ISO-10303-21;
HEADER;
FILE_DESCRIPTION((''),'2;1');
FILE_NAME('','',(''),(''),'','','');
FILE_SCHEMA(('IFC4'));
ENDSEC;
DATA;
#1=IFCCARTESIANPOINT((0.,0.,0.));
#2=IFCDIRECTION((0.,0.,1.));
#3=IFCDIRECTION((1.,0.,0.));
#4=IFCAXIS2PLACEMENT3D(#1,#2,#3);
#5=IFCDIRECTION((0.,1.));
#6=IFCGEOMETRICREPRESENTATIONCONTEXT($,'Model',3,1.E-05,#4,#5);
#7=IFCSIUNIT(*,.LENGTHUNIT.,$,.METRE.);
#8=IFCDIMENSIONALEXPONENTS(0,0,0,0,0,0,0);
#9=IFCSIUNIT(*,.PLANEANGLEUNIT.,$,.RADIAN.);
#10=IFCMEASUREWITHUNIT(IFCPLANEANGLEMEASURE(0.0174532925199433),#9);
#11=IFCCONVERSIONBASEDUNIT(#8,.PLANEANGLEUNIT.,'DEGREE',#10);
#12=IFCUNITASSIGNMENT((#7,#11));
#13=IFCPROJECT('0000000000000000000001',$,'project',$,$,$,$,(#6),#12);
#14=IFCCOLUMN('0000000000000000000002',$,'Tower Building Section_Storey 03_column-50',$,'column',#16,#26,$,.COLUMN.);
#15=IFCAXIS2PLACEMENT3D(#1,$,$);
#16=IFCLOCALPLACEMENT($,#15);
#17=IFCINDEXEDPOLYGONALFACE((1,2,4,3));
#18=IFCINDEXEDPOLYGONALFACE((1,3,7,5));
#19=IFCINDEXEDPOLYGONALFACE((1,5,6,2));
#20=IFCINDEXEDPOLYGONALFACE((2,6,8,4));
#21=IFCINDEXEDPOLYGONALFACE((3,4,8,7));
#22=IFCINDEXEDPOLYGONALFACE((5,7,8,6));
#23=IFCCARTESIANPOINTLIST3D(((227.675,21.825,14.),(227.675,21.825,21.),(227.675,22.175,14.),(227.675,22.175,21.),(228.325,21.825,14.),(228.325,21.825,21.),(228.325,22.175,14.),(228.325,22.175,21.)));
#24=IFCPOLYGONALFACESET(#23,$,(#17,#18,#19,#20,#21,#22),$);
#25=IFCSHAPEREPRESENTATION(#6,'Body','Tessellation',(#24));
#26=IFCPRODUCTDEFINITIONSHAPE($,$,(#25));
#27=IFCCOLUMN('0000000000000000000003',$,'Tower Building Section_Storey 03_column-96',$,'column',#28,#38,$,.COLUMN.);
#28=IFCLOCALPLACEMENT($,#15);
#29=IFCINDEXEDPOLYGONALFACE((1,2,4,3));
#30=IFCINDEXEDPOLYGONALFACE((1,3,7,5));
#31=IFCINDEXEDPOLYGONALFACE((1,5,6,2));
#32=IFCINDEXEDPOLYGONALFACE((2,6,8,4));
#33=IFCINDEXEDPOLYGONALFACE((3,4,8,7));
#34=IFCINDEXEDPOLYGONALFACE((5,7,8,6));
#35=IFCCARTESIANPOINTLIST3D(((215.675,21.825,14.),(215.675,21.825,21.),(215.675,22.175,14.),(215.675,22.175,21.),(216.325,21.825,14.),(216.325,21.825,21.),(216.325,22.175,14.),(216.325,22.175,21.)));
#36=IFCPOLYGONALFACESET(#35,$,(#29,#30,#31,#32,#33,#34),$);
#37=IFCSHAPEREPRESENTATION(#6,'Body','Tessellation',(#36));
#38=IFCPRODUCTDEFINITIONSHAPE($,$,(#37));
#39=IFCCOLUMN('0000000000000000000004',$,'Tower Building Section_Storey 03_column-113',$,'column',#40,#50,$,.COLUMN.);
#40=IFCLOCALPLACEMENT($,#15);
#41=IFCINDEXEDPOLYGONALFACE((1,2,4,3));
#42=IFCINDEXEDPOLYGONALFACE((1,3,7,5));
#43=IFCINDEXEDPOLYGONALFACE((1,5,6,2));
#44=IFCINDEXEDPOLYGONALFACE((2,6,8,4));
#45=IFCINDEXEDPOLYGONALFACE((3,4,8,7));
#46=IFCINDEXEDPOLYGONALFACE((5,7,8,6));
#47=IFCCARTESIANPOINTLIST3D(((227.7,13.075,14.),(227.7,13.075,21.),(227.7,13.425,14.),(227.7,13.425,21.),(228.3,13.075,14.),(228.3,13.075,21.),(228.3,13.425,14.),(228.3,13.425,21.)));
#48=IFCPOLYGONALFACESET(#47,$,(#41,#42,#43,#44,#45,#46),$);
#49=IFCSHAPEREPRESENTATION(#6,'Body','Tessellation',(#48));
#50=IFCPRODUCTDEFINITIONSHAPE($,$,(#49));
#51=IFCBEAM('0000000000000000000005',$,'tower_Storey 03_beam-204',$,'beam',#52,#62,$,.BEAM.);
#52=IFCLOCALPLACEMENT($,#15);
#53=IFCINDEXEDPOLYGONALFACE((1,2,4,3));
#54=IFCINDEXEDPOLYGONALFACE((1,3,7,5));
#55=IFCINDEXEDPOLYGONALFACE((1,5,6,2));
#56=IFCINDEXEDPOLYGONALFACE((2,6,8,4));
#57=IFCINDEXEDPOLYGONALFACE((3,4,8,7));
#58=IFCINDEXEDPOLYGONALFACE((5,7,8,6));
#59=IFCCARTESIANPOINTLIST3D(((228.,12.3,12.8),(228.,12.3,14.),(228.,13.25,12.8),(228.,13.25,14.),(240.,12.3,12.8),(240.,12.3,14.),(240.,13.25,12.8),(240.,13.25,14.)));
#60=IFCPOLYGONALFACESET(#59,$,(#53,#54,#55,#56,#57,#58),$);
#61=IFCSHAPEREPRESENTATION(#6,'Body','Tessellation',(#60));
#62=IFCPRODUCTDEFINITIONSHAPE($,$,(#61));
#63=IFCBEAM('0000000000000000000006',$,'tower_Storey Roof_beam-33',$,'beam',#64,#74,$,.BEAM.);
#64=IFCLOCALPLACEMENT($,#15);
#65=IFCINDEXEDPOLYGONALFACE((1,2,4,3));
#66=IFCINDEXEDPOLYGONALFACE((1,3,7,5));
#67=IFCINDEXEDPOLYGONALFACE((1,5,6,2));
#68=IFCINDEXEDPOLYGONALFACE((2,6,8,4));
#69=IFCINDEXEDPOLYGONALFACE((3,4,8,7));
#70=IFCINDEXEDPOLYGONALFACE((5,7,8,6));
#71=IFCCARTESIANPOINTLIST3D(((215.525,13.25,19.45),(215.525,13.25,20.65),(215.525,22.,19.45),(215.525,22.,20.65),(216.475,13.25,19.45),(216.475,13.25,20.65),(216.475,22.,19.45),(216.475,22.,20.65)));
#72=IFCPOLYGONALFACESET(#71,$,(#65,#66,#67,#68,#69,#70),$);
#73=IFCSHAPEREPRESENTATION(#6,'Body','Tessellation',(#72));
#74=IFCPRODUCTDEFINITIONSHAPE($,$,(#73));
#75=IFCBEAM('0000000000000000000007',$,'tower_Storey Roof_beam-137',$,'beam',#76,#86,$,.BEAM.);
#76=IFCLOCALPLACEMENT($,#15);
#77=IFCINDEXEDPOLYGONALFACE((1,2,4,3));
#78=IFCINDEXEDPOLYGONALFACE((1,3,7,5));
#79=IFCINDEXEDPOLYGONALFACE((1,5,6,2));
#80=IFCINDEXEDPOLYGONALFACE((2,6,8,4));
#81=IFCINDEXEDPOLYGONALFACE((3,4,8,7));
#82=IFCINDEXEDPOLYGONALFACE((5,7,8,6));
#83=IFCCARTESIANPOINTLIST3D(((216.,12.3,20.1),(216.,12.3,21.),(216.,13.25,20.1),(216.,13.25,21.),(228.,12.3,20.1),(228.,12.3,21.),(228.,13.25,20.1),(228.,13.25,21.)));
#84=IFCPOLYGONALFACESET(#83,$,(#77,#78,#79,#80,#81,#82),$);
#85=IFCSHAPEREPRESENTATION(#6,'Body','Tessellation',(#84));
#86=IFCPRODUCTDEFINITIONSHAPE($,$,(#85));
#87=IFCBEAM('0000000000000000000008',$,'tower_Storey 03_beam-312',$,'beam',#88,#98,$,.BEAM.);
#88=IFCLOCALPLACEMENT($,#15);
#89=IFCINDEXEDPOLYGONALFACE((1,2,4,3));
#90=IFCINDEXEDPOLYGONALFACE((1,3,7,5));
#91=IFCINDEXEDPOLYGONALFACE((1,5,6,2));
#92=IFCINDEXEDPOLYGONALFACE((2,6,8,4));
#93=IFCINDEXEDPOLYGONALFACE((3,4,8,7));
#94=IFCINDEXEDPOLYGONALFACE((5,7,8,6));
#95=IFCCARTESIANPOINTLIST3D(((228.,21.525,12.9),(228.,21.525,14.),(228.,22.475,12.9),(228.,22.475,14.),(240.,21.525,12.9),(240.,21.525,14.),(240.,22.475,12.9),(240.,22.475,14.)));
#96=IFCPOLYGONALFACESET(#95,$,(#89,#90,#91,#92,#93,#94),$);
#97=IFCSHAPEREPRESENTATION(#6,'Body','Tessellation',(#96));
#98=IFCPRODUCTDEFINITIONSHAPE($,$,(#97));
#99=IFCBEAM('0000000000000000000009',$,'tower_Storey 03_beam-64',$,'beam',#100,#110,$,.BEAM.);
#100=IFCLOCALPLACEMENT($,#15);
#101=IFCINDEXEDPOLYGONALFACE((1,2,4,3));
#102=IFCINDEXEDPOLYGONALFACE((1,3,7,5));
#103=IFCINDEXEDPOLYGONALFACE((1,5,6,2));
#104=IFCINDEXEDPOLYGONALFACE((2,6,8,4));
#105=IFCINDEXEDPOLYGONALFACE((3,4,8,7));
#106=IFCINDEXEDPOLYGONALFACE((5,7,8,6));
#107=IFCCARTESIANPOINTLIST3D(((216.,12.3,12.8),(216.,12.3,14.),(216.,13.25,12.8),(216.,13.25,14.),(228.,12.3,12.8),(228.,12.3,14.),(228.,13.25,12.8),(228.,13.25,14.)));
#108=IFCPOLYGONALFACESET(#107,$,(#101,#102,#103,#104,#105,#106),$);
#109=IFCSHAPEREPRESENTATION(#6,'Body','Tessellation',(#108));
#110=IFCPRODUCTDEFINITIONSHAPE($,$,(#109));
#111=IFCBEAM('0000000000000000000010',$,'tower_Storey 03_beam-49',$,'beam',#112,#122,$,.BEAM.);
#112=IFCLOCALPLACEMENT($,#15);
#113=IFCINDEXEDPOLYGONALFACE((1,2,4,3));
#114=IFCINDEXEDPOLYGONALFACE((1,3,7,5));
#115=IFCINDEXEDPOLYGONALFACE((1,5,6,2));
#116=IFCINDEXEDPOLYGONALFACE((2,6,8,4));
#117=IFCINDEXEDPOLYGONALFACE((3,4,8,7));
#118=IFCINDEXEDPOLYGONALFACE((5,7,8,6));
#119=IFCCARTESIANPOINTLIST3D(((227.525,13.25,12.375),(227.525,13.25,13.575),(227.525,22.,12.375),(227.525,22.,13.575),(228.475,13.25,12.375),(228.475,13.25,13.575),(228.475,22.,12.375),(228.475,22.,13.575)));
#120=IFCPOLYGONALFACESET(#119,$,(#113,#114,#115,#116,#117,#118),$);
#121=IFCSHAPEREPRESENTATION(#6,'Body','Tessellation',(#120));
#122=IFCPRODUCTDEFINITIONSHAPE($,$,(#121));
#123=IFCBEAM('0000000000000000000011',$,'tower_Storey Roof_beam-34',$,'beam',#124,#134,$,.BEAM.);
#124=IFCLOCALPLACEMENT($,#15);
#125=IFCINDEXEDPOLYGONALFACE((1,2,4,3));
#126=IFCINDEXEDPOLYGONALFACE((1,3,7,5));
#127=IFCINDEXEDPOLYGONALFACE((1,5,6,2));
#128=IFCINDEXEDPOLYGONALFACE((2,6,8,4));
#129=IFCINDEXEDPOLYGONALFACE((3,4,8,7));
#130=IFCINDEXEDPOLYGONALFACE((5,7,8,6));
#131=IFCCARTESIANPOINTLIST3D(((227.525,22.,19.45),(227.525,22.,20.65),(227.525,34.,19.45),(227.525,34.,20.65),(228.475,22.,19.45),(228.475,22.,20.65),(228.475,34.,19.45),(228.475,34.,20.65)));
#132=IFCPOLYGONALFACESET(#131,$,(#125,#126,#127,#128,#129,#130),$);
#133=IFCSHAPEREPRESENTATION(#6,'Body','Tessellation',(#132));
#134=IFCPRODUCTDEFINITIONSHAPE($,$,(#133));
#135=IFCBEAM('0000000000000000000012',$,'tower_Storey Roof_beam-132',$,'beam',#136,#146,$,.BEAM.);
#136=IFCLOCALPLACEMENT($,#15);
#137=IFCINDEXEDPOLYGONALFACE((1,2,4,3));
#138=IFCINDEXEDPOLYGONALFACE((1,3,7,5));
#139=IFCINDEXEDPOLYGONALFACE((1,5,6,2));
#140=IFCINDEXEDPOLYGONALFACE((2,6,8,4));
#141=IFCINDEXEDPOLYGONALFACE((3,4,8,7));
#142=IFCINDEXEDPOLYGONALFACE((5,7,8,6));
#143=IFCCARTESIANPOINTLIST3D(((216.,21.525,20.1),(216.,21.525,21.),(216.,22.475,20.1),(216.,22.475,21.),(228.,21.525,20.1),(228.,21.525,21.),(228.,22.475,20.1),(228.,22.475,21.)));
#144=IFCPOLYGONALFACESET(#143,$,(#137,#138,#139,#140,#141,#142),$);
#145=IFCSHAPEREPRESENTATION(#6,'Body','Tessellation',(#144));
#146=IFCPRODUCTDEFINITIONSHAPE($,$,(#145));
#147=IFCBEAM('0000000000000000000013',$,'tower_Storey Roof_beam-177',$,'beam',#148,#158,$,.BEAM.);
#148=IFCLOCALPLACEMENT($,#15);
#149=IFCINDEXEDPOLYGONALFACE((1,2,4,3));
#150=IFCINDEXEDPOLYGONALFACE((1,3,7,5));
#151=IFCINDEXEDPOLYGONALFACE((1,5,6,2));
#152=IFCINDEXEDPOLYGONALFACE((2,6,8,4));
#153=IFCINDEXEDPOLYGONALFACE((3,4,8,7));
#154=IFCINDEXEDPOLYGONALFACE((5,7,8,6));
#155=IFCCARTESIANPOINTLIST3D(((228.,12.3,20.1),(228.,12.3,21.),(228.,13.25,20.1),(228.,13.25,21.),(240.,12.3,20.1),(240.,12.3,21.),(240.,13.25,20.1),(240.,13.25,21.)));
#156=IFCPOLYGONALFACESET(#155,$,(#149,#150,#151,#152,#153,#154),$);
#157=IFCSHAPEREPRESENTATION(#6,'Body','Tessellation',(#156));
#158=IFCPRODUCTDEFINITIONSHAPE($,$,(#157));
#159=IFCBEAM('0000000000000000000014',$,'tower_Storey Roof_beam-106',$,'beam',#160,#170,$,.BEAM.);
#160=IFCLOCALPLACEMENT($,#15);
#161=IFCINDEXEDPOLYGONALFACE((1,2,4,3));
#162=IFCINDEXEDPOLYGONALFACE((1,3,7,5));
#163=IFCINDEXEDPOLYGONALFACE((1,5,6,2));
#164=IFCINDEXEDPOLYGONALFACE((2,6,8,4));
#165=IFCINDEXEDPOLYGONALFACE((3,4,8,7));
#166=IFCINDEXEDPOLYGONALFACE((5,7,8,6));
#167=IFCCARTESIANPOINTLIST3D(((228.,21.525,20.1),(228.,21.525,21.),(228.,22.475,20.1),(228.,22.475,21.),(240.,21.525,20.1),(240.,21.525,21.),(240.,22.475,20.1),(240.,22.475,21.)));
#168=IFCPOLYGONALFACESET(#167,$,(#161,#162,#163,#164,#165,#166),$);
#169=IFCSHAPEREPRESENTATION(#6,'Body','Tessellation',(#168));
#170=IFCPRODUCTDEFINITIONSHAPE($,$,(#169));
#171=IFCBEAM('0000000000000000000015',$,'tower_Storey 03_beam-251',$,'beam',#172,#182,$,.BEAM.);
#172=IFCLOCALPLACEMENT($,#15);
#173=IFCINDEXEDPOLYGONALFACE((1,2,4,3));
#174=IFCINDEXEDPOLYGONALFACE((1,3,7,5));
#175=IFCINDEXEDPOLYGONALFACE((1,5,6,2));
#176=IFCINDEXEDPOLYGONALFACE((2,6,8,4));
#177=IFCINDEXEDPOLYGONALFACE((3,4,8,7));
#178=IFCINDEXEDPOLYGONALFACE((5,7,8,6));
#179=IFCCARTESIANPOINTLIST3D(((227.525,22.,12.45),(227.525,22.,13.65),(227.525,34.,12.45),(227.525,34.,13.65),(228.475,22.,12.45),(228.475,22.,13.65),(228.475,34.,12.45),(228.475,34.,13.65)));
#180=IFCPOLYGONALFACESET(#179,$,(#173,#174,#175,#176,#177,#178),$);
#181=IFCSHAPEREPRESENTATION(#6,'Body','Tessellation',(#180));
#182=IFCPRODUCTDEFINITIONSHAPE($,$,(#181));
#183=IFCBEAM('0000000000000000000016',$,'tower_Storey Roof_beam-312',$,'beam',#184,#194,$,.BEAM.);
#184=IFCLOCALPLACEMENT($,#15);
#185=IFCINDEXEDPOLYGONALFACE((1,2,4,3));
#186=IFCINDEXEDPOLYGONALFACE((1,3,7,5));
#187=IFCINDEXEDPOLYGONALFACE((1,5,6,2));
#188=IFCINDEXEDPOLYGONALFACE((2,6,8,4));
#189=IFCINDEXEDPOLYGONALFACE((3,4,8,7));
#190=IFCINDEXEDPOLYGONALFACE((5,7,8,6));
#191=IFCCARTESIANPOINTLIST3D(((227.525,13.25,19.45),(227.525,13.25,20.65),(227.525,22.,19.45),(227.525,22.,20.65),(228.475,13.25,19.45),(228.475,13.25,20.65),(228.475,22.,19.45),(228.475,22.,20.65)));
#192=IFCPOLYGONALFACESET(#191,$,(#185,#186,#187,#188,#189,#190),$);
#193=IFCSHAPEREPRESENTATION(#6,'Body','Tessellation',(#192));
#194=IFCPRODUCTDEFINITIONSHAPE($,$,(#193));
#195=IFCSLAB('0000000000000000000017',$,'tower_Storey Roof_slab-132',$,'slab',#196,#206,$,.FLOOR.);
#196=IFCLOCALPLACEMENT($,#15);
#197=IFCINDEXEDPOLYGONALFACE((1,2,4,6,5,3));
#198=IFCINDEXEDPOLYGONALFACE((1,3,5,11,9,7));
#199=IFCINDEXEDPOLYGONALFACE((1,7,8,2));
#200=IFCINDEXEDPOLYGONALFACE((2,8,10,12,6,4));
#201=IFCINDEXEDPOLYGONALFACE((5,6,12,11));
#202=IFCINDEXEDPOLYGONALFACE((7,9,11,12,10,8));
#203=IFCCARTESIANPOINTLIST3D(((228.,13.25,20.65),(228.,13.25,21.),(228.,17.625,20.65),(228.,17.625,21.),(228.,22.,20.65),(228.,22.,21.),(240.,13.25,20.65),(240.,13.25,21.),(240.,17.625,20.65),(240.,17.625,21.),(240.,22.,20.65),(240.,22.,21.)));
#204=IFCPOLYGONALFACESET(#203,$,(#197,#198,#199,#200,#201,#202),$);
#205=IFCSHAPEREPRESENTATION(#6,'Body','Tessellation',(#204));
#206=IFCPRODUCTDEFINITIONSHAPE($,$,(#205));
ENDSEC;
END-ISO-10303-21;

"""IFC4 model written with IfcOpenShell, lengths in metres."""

from ifc_helpers import new_model, entity, si_unit, converted_unit, direction, frame, origin_with_axes, place, context, project, polyline, outline, extrude, element, save


model = new_model("IFC4")

# Units and contexts
model_context = context("Model", 3, precision=1e-05, world=origin_with_axes(), true_north=direction((0.0, 1.0)))
ifc_project = project(units=[si_unit("LENGTHUNIT", "METRE"), converted_unit("PLANEANGLEUNIT", "DEGREE", entity("IfcPlaneAngleMeasure", 0.0174532925199433), si_unit("PLANEANGLEUNIT", "RADIAN"), dimensions=[0, 0, 0, 0, 0, 0, 0])], contexts=[model_context])

# Columns
placement_1 = place(None, origin_with_axes())
placement_2 = place(placement_1, frame((0.0, 0.0, 14.0), z_axis=(0.0, 0.0, 1.0), x_axis=(1.0, 0.0, 0.0)))
for number, where, z_axis, x_axis, name in (
    (1, (228.0, 22.0, 0.0), (0.0, 0.0, 1.0), (1.0, 0.0, 0.0), "Tower Building Section_Storey 03_column-50"),
    (2, (216.0, 22.0, 0.0), (0.0, 0.0, 1.0), (1.0, 0.0, 0.0), "Tower Building Section_Storey 03_column-96"),
):
    element("IfcColumn", number, at=place(placement_2, frame(where, z_axis=z_axis, x_axis=x_axis)), Name=name, ObjectType="column", PredefinedType="COLUMN", context=model_context, body=[
        extrude(outline(polyline([(-0.325, -0.175, 0.0), (0.325, -0.175, 0.0), (0.325, 0.175, 0.0), (-0.325, 0.175, 0.0), (-0.325, -0.175, 0.0)])), origin_with_axes(), (0.0, 0.0, 1.0), 7.0),
    ])
column_placement = place(placement_2, frame((228.0, 13.25, 0.0), z_axis=(0.0, 0.0, 1.0), x_axis=(1.0, 0.0, 0.0)))
element("IfcColumn", 3, at=column_placement, Name="Tower Building Section_Storey 03_column-113", ObjectType="column", PredefinedType="COLUMN", context=model_context, body=[
    extrude(outline(polyline([(-0.3, -0.175, 0.0), (0.3, -0.175, 0.0), (0.3, 0.175, 0.0), (-0.3, 0.175, 0.0), (-0.3, -0.175, 0.0)])), origin_with_axes(), (0.0, 0.0, 1.0), 7.0),
])

# Beams
beam_1_placement = place(placement_2, frame((228.0, 12.775, -0.6), z_axis=(1.0, 0.0, 0.0), x_axis=(0.0, 1.0, 0.0)))
element("IfcBeam", 4, at=beam_1_placement, Name="tower_Storey 03_beam-204", ObjectType="beam", PredefinedType="BEAM", context=model_context, body=[
    extrude(outline(polyline([(0.475, 0.6, 0.0), (-0.475, 0.6, 0.0), (-0.475, -0.6, 0.0), (0.475, -0.6, 0.0), (0.475, 0.6, 0.0)])), origin_with_axes(), (0.0, 0.0, 1.0), 12.0),
])
placement_3 = place(placement_1, frame((0.0, 0.0, 21.0), z_axis=(0.0, 0.0, 1.0), x_axis=(1.0, 0.0, 0.0)))
beam_2_placement = place(placement_3, frame((216.0, 13.25, -0.95), z_axis=(0.0, 1.0, 0.0), x_axis=(-1.0, 0.0, 0.0)))
element("IfcBeam", 5, at=beam_2_placement, Name="tower_Storey Roof_beam-33", ObjectType="beam", PredefinedType="BEAM", context=model_context, body=[
    extrude(outline(polyline([(0.475, 0.6, 0.0), (-0.475, 0.6, 0.0), (-0.475, -0.6, 0.0), (0.475, -0.6, 0.0), (0.475, 0.6, 0.0)])), origin_with_axes(), (0.0, 0.0, 1.0), 8.75),
])
beam_3_placement = place(placement_3, frame((216.0, 12.775, -0.45), z_axis=(1.0, 0.0, 0.0), x_axis=(0.0, 1.0, 0.0)))
element("IfcBeam", 6, at=beam_3_placement, Name="tower_Storey Roof_beam-137", ObjectType="beam", PredefinedType="BEAM", context=model_context, body=[
    extrude(outline(polyline([(0.475, 0.45, 0.0), (-0.475, 0.45, 0.0), (-0.475, -0.45, 0.0), (0.475, -0.45, 0.0), (0.475, 0.45, 0.0)])), origin_with_axes(), (0.0, 0.0, 1.0), 12.0),
])
beam_4_placement = place(placement_2, frame((228.0, 22.0, -0.55), z_axis=(1.0, 0.0, 0.0), x_axis=(0.0, 1.0, 0.0)))
element("IfcBeam", 7, at=beam_4_placement, Name="tower_Storey 03_beam-312", ObjectType="beam", PredefinedType="BEAM", context=model_context, body=[
    extrude(outline(polyline([(0.475, 0.55, 0.0), (-0.475, 0.55, 0.0), (-0.475, -0.55, 0.0), (0.475, -0.55, 0.0), (0.475, 0.55, 0.0)])), origin_with_axes(), (0.0, 0.0, 1.0), 12.0),
])
beam_5_placement = place(placement_2, frame((216.0, 12.775, -0.6), z_axis=(1.0, 0.0, 0.0), x_axis=(0.0, 1.0, 0.0)))
element("IfcBeam", 8, at=beam_5_placement, Name="tower_Storey 03_beam-64", ObjectType="beam", PredefinedType="BEAM", context=model_context, body=[
    extrude(outline(polyline([(0.475, 0.6, 0.0), (-0.475, 0.6, 0.0), (-0.475, -0.6, 0.0), (0.475, -0.6, 0.0), (0.475, 0.6, 0.0)])), origin_with_axes(), (0.0, 0.0, 1.0), 12.0),
])
beam_6_placement = place(placement_2, frame((228.0, 13.25, -1.025), z_axis=(0.0, 1.0, 0.0), x_axis=(-1.0, 0.0, 0.0)))
element("IfcBeam", 9, at=beam_6_placement, Name="tower_Storey 03_beam-49", ObjectType="beam", PredefinedType="BEAM", context=model_context, body=[
    extrude(outline(polyline([(0.475, 0.6, 0.0), (-0.475, 0.6, 0.0), (-0.475, -0.6, 0.0), (0.475, -0.6, 0.0), (0.475, 0.6, 0.0)])), origin_with_axes(), (0.0, 0.0, 1.0), 8.75),
])
beam_7_placement = place(placement_3, frame((228.0, 22.0, -0.95), z_axis=(0.0, 1.0, 0.0), x_axis=(-1.0, 0.0, 0.0)))
element("IfcBeam", 10, at=beam_7_placement, Name="tower_Storey Roof_beam-34", ObjectType="beam", PredefinedType="BEAM", context=model_context, body=[
    extrude(outline(polyline([(0.475, 0.6, 0.0), (-0.475, 0.6, 0.0), (-0.475, -0.6, 0.0), (0.475, -0.6, 0.0), (0.475, 0.6, 0.0)])), origin_with_axes(), (0.0, 0.0, 1.0), 12.0),
])
for number, where, z_axis, x_axis, name in (
    (11, (216.0, 22.0, -0.45), (1.0, 0.0, 0.0), (0.0, 1.0, 0.0), "tower_Storey Roof_beam-132"),
    (12, (228.0, 12.775, -0.45), (1.0, 0.0, 0.0), (0.0, 1.0, 0.0), "tower_Storey Roof_beam-177"),
    (13, (228.0, 22.0, -0.45), (1.0, 0.0, 0.0), (0.0, 1.0, 0.0), "tower_Storey Roof_beam-106"),
):
    element("IfcBeam", number, at=place(placement_3, frame(where, z_axis=z_axis, x_axis=x_axis)), Name=name, ObjectType="beam", PredefinedType="BEAM", context=model_context, body=[
        extrude(outline(polyline([(0.475, 0.45, 0.0), (-0.475, 0.45, 0.0), (-0.475, -0.45, 0.0), (0.475, -0.45, 0.0), (0.475, 0.45, 0.0)])), origin_with_axes(), (0.0, 0.0, 1.0), 12.0),
    ])
beam_8_placement = place(placement_2, frame((228.0, 22.0, -0.95), z_axis=(0.0, 1.0, 0.0), x_axis=(-1.0, 0.0, 0.0)))
element("IfcBeam", 14, at=beam_8_placement, Name="tower_Storey 03_beam-251", ObjectType="beam", PredefinedType="BEAM", context=model_context, body=[
    extrude(outline(polyline([(0.475, 0.6, 0.0), (-0.475, 0.6, 0.0), (-0.475, -0.6, 0.0), (0.475, -0.6, 0.0), (0.475, 0.6, 0.0)])), origin_with_axes(), (0.0, 0.0, 1.0), 12.0),
])
beam_9_placement = place(placement_3, frame((228.0, 13.25, -0.95), z_axis=(0.0, 1.0, 0.0), x_axis=(-1.0, 0.0, 0.0)))
element("IfcBeam", 15, at=beam_9_placement, Name="tower_Storey Roof_beam-312", ObjectType="beam", PredefinedType="BEAM", context=model_context, body=[
    extrude(outline(polyline([(0.475, 0.6, 0.0), (-0.475, 0.6, 0.0), (-0.475, -0.6, 0.0), (0.475, -0.6, 0.0), (0.475, 0.6, 0.0)])), origin_with_axes(), (0.0, 0.0, 1.0), 8.75),
])

# Slab
for number, where, z_axis, x_axis, name in (
    (16, (234.0, 17.625, -0.35), (0.0, 0.0, 1.0), (1.0, 0.0, 0.0), "tower_Storey Roof_slab-132"),
):
    element("IfcSlab", number, at=place(placement_3, frame(where, z_axis=z_axis, x_axis=x_axis)), Name=name, ObjectType="slab", PredefinedType="FLOOR", context=model_context, body=[
        extrude(outline(polyline([(-6.0, 0.0, 0.0), (-6.0, -4.375, 0.0), (6.0, -4.375, 0.0), (6.0, 0.0, 0.0), (6.0, 4.375, 0.0), (-6.0, 4.375, 0.0), (-6.0, 0.0, 0.0)])), origin_with_axes(), (0.0, 0.0, 1.0), 0.35),
    ])

save(model, "model.ifc")
